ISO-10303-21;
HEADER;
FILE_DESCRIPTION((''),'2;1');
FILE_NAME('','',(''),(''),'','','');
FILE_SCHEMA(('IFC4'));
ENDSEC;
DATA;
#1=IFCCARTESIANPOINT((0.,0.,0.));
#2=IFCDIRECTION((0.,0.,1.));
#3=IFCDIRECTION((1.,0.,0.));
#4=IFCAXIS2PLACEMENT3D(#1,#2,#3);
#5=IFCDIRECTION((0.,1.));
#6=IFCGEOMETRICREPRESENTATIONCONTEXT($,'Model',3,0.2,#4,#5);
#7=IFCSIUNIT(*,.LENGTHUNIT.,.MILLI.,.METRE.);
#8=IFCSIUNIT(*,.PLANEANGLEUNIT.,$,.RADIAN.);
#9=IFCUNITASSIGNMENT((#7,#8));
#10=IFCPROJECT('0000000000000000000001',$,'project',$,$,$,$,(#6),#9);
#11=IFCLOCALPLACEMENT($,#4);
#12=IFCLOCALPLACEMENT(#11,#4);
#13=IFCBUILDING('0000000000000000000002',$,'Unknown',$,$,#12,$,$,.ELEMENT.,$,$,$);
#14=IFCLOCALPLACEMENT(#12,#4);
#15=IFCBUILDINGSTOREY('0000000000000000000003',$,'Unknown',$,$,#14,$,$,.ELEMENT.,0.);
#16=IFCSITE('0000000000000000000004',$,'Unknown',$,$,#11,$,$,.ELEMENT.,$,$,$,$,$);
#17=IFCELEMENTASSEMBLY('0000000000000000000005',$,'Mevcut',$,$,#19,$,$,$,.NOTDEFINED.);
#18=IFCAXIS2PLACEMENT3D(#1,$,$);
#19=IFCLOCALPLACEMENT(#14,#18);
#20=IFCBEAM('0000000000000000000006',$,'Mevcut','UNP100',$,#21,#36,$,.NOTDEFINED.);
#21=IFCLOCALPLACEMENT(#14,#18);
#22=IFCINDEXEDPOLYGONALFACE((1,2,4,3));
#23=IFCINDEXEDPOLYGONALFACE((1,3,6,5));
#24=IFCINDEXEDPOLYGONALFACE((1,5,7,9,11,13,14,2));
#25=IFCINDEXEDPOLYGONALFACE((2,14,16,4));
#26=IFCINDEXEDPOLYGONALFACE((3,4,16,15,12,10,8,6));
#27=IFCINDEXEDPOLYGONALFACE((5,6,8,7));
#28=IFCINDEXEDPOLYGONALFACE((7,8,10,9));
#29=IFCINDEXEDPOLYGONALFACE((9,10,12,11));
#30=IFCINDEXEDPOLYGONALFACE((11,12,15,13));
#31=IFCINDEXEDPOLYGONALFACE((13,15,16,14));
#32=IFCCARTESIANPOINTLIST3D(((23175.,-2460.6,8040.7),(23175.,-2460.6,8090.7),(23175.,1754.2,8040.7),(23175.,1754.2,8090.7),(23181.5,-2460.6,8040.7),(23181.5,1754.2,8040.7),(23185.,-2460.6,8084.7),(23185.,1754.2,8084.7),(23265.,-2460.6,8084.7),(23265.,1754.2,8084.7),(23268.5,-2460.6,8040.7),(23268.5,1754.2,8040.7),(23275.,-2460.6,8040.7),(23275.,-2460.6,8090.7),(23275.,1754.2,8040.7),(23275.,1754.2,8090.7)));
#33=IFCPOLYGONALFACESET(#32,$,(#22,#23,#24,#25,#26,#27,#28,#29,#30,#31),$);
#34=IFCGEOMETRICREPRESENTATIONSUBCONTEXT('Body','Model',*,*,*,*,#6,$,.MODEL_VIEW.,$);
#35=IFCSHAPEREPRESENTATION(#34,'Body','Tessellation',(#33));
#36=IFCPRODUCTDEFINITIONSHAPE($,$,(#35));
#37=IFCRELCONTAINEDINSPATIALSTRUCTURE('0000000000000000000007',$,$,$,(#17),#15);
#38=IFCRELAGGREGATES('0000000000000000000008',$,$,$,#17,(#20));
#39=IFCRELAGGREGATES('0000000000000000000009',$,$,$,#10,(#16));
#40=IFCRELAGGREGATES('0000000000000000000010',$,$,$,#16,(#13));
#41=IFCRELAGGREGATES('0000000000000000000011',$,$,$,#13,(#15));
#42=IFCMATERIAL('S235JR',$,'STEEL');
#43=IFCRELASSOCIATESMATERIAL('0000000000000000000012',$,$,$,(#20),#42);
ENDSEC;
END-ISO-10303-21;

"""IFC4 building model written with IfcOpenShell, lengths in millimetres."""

from ifc_helpers import new_model, si_unit, direction, frame, origin_with_axes, place, context, subcontext, project, spatial, line, indexed_curve, outline, extrude, material, element, aggregate, save


model = new_model("IFC4")

# Units and contexts
model_context = context("Model", 3, precision=0.2, world=origin_with_axes(), true_north=direction((0.0, 1.0)))
body_context = subcontext(model_context, "Body", "Model", "MODEL_VIEW")
ifc_project = project(units=[si_unit("LENGTHUNIT", "METRE", prefix="MILLI"), si_unit("PLANEANGLEUNIT", "RADIAN")], contexts=[model_context])

# Site, building, storey
site_placement = place(None, origin_with_axes())
site = spatial("IfcSite", under=ifc_project, at=site_placement, Name="Unknown", CompositionType="ELEMENT")
building_placement = place(site_placement, origin_with_axes())
building = spatial("IfcBuilding", under=site, at=building_placement, Name="Unknown", CompositionType="ELEMENT")
storey_placement = place(building_placement, origin_with_axes())
storey = spatial("IfcBuildingStorey", under=building, at=storey_placement, Name="Unknown", CompositionType="ELEMENT", Elevation=0.0)

# Shared definitions
ifc_material = material(Name="S235JR", Category="STEEL")

# Element assembly, beam
assembly_1_placement = place(storey_placement, frame((23225.0, 1754.2, 8065.7), z_axis=(0.0, 0.0, -1.0), x_axis=(0.0, -1.0, 0.0)))
assembly_1 = element("IfcElementAssembly", 1, at=assembly_1_placement, inside=storey, Name="Mevcut", PredefinedType="NOTDEFINED")
beam_1_placement = place(assembly_1_placement, origin_with_axes())
beam_1 = element("IfcBeam", 2, at=beam_1_placement, material=ifc_material, Name="Mevcut", Description="UNP100", PredefinedType="NOTDEFINED", context=body_context, shape_type="SolidModel", body=[
    extrude(outline(indexed_curve([(-25.0, -50.0), (25.0, -50.0), (25.0, -43.5), (-19.0, -40.0), (-19.0, 40.0), (25.0, 43.5), (25.0, 50.0), (-25.0, 50.0)], segments=[line(1, 2, 3, 4, 5, 6, 7, 8, 1)])), frame((0.0, 0.0, 0.0), z_axis=(-1.0, 0.0, 0.0), x_axis=(0.0, 0.0, 1.0)), (0.0, 0.0, -1.0), 4214.9),
])
aggregate(assembly_1, [beam_1])

save(model, "model.ifc")
